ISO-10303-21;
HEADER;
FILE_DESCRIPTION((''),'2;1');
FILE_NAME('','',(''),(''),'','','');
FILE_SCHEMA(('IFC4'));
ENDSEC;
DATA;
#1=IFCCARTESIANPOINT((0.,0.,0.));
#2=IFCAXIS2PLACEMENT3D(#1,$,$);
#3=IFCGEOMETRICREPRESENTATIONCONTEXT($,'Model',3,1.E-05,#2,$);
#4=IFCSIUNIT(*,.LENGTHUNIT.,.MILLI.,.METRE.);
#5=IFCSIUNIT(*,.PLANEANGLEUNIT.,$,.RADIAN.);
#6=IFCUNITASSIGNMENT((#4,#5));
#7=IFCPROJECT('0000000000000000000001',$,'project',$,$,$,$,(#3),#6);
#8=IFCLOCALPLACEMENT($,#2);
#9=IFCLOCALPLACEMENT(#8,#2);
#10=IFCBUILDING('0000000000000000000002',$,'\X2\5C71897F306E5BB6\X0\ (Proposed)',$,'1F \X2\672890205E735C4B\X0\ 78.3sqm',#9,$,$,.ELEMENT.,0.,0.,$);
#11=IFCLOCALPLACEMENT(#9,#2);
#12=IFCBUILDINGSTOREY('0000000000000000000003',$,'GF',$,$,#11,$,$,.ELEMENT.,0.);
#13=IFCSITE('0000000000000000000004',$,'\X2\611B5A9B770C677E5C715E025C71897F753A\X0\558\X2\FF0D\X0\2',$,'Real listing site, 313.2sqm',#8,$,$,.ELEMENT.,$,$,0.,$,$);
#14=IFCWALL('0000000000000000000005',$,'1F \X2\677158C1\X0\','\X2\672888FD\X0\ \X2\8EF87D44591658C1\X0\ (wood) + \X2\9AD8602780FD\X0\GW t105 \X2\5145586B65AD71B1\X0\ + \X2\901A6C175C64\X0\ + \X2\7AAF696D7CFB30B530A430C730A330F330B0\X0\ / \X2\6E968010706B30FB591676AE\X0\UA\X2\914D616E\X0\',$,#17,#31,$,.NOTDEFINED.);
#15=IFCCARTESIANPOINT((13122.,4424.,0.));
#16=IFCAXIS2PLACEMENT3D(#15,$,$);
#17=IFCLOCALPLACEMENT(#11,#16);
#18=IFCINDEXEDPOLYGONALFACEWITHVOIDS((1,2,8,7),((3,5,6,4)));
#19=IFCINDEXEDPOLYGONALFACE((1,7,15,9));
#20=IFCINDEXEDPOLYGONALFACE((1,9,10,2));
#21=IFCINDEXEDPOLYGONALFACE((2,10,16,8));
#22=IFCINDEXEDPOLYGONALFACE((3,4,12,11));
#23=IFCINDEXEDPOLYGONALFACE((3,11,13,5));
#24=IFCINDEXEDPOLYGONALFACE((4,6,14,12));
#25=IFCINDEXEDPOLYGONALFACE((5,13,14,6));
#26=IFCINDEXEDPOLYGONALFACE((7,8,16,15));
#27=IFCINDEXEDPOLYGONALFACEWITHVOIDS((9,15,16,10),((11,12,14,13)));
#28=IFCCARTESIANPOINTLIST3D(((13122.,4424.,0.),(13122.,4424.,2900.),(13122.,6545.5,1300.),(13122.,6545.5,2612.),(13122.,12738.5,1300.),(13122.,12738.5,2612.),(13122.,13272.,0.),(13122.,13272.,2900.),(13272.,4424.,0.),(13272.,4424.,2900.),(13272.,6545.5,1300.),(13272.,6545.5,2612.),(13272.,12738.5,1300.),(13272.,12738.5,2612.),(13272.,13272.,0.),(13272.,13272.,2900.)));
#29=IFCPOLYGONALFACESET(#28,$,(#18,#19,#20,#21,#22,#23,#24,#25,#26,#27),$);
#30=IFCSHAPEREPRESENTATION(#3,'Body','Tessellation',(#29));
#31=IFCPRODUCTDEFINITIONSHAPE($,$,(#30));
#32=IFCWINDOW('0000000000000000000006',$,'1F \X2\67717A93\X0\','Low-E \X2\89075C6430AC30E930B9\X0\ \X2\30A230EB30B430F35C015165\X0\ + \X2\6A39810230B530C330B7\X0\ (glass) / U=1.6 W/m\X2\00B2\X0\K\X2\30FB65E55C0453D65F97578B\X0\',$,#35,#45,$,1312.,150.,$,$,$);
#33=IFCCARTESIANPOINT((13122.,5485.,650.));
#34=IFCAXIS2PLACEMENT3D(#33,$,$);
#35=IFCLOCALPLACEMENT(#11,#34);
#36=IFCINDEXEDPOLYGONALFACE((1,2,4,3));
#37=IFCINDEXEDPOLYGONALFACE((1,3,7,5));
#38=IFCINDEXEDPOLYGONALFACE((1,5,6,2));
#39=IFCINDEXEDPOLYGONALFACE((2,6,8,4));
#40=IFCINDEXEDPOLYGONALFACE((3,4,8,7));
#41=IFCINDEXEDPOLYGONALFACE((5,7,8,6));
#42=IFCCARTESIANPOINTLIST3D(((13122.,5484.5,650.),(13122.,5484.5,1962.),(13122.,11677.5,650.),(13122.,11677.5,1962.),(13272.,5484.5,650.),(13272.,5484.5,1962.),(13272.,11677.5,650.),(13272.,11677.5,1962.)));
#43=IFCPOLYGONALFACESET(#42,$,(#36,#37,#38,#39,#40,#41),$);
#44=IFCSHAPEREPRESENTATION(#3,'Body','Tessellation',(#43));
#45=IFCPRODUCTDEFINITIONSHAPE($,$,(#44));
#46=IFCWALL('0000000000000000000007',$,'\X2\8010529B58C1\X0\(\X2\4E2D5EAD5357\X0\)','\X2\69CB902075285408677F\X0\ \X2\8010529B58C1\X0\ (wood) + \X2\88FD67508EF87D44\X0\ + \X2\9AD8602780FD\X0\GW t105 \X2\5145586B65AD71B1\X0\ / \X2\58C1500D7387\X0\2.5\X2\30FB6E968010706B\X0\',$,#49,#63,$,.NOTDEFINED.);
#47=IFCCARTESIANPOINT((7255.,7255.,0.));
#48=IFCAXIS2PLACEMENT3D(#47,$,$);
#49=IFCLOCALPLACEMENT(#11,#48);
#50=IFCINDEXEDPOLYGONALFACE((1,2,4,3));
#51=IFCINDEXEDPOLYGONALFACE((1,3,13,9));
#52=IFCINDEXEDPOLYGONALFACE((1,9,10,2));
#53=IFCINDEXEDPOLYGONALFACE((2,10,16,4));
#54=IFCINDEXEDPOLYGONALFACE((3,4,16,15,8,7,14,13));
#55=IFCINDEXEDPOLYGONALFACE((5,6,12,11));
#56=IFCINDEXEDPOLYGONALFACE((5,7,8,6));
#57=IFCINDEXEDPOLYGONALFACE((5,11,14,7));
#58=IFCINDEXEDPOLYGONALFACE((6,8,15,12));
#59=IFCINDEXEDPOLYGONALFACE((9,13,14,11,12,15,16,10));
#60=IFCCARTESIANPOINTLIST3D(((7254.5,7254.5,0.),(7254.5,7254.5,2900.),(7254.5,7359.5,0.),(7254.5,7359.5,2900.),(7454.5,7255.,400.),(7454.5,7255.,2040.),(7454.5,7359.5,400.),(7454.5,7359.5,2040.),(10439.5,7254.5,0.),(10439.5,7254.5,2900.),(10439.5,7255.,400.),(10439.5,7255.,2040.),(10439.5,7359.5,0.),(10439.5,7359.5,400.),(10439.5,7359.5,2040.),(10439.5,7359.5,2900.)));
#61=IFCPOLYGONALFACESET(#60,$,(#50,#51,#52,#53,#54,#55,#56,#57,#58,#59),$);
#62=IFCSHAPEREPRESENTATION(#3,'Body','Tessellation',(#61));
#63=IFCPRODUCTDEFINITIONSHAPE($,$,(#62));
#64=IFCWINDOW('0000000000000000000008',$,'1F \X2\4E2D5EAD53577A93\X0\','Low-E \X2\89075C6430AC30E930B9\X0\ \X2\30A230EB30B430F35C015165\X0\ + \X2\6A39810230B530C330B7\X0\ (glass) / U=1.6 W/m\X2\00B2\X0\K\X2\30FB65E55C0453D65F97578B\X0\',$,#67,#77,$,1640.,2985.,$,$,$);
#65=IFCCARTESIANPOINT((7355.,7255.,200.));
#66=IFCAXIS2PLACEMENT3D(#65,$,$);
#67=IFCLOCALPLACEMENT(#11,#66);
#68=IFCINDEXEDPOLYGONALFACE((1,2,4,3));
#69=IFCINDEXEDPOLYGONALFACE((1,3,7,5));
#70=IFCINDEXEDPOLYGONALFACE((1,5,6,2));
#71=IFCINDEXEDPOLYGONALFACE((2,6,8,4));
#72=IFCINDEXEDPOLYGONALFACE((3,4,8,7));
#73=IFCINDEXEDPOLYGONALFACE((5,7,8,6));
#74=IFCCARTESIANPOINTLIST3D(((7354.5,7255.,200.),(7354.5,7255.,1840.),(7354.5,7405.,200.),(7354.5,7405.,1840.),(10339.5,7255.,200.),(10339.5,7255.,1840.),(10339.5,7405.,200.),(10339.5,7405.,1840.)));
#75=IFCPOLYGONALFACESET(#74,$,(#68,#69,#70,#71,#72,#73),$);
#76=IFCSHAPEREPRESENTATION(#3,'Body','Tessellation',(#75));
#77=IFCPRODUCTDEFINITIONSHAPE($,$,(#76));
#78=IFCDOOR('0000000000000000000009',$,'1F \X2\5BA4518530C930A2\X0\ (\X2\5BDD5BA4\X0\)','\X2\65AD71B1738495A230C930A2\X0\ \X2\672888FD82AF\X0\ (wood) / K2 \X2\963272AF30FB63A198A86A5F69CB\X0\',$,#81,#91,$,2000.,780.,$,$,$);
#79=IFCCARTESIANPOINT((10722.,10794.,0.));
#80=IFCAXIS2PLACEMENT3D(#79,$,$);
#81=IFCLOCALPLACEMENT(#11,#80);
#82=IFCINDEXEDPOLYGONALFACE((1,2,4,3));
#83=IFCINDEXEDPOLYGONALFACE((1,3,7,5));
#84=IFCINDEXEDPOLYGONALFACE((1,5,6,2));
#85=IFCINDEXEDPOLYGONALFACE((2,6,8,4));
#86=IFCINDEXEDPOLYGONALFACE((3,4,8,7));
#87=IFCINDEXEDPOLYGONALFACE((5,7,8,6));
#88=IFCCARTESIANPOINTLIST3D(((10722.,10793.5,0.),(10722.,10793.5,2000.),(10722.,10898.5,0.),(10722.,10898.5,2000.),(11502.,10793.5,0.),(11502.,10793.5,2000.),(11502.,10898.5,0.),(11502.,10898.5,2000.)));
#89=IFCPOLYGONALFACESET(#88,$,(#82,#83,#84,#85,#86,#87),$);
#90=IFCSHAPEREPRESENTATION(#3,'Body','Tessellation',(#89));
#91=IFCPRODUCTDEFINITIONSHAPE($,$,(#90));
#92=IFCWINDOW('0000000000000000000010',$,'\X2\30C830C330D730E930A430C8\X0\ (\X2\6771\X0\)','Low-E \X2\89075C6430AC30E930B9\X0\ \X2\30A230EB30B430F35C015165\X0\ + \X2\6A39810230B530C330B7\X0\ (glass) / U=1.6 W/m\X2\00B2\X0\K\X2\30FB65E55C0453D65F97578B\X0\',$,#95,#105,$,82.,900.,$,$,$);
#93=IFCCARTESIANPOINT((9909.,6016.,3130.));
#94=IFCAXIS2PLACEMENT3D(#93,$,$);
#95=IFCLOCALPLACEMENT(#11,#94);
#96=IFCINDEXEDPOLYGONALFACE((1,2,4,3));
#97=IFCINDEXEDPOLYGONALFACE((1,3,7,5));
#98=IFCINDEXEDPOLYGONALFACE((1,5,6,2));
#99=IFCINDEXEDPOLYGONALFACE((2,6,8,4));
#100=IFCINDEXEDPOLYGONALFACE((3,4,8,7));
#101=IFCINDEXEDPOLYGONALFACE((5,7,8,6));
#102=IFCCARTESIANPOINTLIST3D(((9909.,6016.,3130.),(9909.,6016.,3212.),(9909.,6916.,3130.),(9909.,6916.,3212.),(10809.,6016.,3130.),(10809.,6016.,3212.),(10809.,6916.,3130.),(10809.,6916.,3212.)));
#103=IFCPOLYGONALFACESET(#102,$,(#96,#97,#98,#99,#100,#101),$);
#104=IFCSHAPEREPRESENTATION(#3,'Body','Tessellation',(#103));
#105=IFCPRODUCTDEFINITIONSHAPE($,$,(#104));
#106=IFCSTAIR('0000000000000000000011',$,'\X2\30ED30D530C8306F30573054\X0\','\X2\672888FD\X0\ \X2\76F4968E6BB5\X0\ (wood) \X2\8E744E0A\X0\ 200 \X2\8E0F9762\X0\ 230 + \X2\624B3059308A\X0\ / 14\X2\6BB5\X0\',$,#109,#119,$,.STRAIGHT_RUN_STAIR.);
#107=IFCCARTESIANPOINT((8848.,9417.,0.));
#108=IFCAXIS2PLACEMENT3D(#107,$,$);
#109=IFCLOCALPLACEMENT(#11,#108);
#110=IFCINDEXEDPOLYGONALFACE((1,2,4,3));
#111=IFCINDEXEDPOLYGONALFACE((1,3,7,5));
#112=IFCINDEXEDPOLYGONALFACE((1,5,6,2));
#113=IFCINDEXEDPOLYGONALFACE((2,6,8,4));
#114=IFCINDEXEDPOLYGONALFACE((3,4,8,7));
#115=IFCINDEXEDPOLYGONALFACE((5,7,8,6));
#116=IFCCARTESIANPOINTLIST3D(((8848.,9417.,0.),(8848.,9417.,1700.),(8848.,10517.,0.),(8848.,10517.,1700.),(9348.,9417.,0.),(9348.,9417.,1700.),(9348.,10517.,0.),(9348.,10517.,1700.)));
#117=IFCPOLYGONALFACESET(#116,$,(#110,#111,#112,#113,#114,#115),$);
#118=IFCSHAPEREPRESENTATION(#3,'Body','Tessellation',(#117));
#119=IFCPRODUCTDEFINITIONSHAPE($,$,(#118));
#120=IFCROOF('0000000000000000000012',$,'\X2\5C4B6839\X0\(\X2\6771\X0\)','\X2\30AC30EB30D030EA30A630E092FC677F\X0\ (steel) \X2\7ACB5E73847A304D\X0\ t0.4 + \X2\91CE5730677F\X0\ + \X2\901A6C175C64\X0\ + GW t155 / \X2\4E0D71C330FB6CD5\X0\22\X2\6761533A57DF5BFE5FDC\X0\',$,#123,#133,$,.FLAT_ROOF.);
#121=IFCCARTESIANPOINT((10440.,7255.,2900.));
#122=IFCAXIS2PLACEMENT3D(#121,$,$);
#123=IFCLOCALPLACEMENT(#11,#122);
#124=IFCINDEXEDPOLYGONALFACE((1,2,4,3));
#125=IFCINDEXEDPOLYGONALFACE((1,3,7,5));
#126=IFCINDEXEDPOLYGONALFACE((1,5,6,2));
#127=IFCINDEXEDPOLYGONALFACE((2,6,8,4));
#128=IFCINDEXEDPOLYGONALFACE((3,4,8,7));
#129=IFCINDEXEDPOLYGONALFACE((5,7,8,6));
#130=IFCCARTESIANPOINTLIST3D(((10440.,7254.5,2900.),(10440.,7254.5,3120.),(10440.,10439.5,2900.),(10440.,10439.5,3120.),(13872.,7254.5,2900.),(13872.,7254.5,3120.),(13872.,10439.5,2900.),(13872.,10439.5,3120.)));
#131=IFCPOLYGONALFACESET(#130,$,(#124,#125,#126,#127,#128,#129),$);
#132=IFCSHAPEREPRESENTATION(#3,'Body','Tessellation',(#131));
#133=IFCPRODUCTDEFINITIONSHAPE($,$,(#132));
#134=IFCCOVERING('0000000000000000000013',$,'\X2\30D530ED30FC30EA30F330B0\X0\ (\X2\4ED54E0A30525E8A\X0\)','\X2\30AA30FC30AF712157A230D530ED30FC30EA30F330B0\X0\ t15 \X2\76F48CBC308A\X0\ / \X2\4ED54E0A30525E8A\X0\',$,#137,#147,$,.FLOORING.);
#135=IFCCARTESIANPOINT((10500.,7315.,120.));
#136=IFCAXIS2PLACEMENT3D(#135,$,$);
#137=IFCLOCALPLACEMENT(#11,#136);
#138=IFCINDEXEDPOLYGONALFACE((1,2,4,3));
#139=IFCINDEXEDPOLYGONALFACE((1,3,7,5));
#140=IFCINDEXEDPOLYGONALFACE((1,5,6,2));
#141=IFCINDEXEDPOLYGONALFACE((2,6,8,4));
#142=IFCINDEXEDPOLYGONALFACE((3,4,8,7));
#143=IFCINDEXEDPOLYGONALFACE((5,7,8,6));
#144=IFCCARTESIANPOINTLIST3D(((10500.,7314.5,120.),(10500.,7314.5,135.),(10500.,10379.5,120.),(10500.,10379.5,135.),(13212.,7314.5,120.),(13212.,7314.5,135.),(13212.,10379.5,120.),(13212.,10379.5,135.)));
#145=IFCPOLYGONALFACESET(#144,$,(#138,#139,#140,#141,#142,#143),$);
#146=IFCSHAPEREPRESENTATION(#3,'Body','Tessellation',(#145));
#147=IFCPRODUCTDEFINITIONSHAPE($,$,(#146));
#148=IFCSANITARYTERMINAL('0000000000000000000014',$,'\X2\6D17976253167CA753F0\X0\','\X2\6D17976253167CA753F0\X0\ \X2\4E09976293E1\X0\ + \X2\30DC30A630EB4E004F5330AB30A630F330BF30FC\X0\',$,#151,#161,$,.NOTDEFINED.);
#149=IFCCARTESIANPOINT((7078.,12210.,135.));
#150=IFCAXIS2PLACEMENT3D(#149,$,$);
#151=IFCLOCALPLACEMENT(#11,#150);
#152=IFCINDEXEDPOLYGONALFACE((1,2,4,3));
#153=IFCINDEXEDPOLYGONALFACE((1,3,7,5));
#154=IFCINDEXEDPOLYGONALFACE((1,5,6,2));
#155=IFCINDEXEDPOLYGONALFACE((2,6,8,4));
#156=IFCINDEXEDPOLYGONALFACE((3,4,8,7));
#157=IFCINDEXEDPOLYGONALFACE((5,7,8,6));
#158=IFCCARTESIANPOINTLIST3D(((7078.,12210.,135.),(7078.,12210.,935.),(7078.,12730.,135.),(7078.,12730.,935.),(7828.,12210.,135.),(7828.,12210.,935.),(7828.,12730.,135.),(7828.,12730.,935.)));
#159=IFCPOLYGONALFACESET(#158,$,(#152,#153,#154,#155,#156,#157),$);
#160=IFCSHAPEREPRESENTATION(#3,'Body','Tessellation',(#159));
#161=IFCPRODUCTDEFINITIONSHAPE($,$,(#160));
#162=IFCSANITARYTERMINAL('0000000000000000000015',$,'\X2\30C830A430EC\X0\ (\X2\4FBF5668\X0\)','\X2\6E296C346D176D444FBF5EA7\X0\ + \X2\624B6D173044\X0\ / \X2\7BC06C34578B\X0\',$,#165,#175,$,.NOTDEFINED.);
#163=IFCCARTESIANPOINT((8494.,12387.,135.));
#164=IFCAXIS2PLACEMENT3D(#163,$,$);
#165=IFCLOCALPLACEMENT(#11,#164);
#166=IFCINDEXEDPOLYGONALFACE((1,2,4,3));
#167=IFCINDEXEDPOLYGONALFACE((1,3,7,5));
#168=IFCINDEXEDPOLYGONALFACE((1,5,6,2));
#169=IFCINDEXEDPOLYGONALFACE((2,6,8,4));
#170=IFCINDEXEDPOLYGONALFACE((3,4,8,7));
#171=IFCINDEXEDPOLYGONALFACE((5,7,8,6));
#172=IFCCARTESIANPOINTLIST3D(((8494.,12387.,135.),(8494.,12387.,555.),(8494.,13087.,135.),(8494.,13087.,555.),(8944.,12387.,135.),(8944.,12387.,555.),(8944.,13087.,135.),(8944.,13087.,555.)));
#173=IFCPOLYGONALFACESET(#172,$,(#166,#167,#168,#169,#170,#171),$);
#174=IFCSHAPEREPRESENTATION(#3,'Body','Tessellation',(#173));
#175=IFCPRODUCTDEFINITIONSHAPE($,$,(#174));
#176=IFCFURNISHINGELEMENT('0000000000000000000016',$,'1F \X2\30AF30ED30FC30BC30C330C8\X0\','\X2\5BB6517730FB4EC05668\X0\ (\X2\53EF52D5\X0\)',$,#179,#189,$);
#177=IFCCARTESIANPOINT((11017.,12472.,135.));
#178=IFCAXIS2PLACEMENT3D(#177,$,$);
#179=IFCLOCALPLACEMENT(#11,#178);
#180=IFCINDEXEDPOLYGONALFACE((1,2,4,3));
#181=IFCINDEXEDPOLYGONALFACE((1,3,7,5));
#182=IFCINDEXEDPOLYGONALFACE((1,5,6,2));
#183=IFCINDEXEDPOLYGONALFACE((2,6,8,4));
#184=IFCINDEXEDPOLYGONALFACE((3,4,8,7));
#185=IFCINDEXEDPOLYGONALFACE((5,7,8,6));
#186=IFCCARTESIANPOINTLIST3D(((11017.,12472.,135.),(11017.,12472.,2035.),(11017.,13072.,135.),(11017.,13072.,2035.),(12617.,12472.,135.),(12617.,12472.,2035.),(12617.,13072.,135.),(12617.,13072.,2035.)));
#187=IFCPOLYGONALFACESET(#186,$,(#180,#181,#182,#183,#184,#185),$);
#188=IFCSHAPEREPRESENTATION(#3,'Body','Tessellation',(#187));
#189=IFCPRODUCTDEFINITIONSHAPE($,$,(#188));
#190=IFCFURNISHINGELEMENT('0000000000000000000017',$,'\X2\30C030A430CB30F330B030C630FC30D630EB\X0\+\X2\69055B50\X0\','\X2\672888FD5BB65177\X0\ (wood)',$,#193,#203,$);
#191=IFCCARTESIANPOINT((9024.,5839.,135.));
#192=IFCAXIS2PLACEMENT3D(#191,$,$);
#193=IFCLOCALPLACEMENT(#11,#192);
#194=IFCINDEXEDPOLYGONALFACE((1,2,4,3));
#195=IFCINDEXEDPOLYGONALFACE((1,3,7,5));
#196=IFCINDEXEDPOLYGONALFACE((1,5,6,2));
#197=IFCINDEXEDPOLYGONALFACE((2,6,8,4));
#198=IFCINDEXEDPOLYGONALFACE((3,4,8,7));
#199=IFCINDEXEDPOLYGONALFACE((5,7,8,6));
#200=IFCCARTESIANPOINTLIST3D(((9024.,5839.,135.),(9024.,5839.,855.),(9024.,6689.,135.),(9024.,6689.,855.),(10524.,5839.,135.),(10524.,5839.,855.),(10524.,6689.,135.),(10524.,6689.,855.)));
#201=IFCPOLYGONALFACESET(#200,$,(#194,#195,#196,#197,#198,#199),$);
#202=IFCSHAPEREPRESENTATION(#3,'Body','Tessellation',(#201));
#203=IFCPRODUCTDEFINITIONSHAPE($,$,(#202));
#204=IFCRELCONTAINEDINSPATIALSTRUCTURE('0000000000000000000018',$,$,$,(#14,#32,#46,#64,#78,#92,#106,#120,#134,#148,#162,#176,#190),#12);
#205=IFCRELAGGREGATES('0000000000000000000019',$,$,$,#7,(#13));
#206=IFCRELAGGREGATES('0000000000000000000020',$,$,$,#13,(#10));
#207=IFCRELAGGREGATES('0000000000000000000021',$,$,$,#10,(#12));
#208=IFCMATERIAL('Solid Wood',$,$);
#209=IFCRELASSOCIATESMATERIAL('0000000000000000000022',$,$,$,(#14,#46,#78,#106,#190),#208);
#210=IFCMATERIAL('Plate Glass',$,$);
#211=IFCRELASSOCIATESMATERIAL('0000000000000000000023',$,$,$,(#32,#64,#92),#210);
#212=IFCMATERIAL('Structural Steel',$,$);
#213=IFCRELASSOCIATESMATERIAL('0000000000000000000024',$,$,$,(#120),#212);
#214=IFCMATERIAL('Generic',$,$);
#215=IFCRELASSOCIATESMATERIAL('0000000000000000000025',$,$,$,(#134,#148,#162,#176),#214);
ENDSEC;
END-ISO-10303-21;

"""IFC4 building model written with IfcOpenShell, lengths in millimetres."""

from ifc_helpers import new_model, si_unit, frame, frame_2d, origin, place, context, project, spatial, rectangle, extrude, material, element, fill, save


model = new_model("IFC4")

# Units and contexts
model_context = context("Model", 3, precision=1e-05, world=origin())
ifc_project = project(units=[si_unit("LENGTHUNIT", "METRE", prefix="MILLI"), si_unit("PLANEANGLEUNIT", "RADIAN")], contexts=[model_context])

# Site, building, storey
site_placement = place(None, origin())
site = spatial("IfcSite", under=ifc_project, at=site_placement, Name="愛媛県松山市山西町558－2", ObjectType="Real listing site, 313.2sqm", CompositionType="ELEMENT", RefElevation=0.0)
building_placement = place(site_placement, origin())
building = spatial("IfcBuilding", under=site, at=building_placement, Name="山西の家 (Proposed)", ObjectType="1F 木造平屋 78.3sqm", CompositionType="ELEMENT", ElevationOfRefHeight=0.0, ElevationOfTerrain=0.0)
storey_placement = place(building_placement, origin())
storey = spatial("IfcBuildingStorey", under=building, at=storey_placement, Name="GF", CompositionType="ELEMENT", Elevation=0.0)

# Shared definitions
ifc_material_1 = material(Name="Solid Wood")

# Walls, openings, windows
wall_1_placement = place(storey_placement, frame((13122.0, 4424.0, 0.0)))
wall_1 = element("IfcWall", 1, at=wall_1_placement, inside=storey, material=ifc_material_1, Name="1F 東壁", Description="木製 軸組外壁 (wood) + 高性能GW t105 充填断熱 + 通気層 + 窯業系サイディング / 準耐火・外皮UA配慮", PredefinedType="NOTDEFINED", context=model_context, shape_type="SweptSolid", body=[
    extrude(rectangle(XDim=150.0, YDim=8848.0, at=frame_2d((75.0, 4424.0))), frame((13122.0, 4424.0, 0.0)), (0.0, 0.0, 1.0), 2900.0),
])
opening_1_placement = place(storey_placement, frame((13122.0, 5485.0, 650.0)))
opening_1 = element("IfcOpeningElement", 2, at=opening_1_placement, cuts=wall_1, PredefinedType="NOTDEFINED", context=model_context, shape_type="SweptSolid", body=[
    extrude(rectangle(XDim=150.0, YDim=6193.0, at=frame_2d((75.0, 3096.0))), frame((13122.0, 5485.0, 650.0)), (0.0, 0.0, 1.0), 1312.0),
])
ifc_material_2 = material(Name="Plate Glass")
window_1_placement = place(storey_placement, frame((13122.0, 5485.0, 650.0)))
window_1 = element("IfcWindow", 3, at=window_1_placement, inside=storey, material=ifc_material_2, Name="1F 東窓", Description="Low-E 複層ガラス アルゴン封入 + 樹脂サッシ (glass) / U=1.6 W/m²K・日射取得型", OverallHeight=1312.0, OverallWidth=150.0, context=model_context, shape_type="SweptSolid", body=[
    extrude(rectangle(XDim=150.0, YDim=6193.0, at=frame_2d((75.0, 3096.0))), frame((13122.0, 5485.0, 650.0)), (0.0, 0.0, 1.0), 1312.0),
])
fill(opening_1, window_1)
wall_2_placement = place(storey_placement, frame((7255.0, 7255.0, 0.0)))
wall_2 = element("IfcWall", 4, at=wall_2_placement, inside=storey, material=ifc_material_1, Name="耐力壁(中庭南)", Description="構造用合板 耐力壁 (wood) + 製材軸組 + 高性能GW t105 充填断熱 / 壁倍率2.5・準耐火", PredefinedType="NOTDEFINED", context=model_context, shape_type="SweptSolid", body=[
    extrude(rectangle(XDim=3185.0, YDim=105.0, at=frame_2d((1592.0, 52.0))), frame((7255.0, 7255.0, 0.0)), (0.0, 0.0, 1.0), 2900.0),
])
opening_2_placement = place(storey_placement, frame((7355.0, 7255.0, 200.0)))
opening_2 = element("IfcOpeningElement", 5, at=opening_2_placement, cuts=wall_2, PredefinedType="NOTDEFINED", context=model_context, shape_type="SweptSolid", body=[
    extrude(rectangle(XDim=2985.0, YDim=150.0, at=frame_2d((1492.0, 75.0))), frame((7355.0, 7255.0, 200.0)), (0.0, 0.0, 1.0), 1640.0),
])
window_2_placement = place(storey_placement, frame((7355.0, 7255.0, 200.0)))
window_2 = element("IfcWindow", 6, at=window_2_placement, inside=storey, material=ifc_material_2, Name="1F 中庭南窓", Description="Low-E 複層ガラス アルゴン封入 + 樹脂サッシ (glass) / U=1.6 W/m²K・日射取得型", OverallHeight=1640.0, OverallWidth=2985.0, context=model_context, shape_type="SweptSolid", body=[
    extrude(rectangle(XDim=2985.0, YDim=150.0, at=frame_2d((1492.0, 75.0))), frame((7355.0, 7255.0, 200.0)), (0.0, 0.0, 1.0), 1640.0),
])
fill(opening_2, window_2)

# Door
door_placement = place(storey_placement, frame((10722.0, 10794.0, 0.0)))
element("IfcDoor", 7, at=door_placement, inside=storey, material=ifc_material_1, Name="1F 室内ドア (寝室)", Description="断熱玄関ドア 木製芯 (wood) / K2 防犯・採風機構", OverallHeight=2000.0, OverallWidth=780.0, context=model_context, shape_type="SweptSolid", body=[
    extrude(rectangle(XDim=780.0, YDim=105.0, at=frame_2d((390.0, 52.0))), frame((10722.0, 10794.0, 0.0)), (0.0, 0.0, 1.0), 2000.0),
])

# Window
window_3_placement = place(storey_placement, frame((9909.0, 6016.0, 3130.0)))
element("IfcWindow", 8, at=window_3_placement, inside=storey, material=ifc_material_2, Name="トップライト (東)", Description="Low-E 複層ガラス アルゴン封入 + 樹脂サッシ (glass) / U=1.6 W/m²K・日射取得型", OverallHeight=82.0, OverallWidth=900.0, context=model_context, shape_type="SweptSolid", body=[
    extrude(rectangle(XDim=900.0, YDim=900.0, at=frame_2d((450.0, 450.0))), frame((9909.0, 6016.0, 3130.0)), (0.0, 0.0, 1.0), 82.0),
])

# Stair
stair_placement = place(storey_placement, frame((8848.0, 9417.0, 0.0)))
element("IfcStair", 9, at=stair_placement, inside=storey, material=ifc_material_1, Name="ロフトはしご", Description="木製 直階段 (wood) 蹴上 200 踏面 230 + 手すり / 14段", PredefinedType="STRAIGHT_RUN_STAIR", context=model_context, shape_type="SweptSolid", body=[
    extrude(rectangle(XDim=500.0, YDim=1100.0, at=frame_2d((250.0, 550.0))), frame((8848.0, 9417.0, 0.0)), (0.0, 0.0, 1.0), 1700.0),
])

# Roof
ifc_material_3 = material(Name="Structural Steel")
roof_placement = place(storey_placement, frame((10440.0, 7255.0, 2900.0)))
element("IfcRoof", 10, at=roof_placement, inside=storey, material=ifc_material_3, Name="屋根(東)", Description="ガルバリウム鋼板 (steel) 立平葺き t0.4 + 野地板 + 通気層 + GW t155 / 不燃・法22条区域対応", PredefinedType="FLAT_ROOF", context=model_context, shape_type="SweptSolid", body=[
    extrude(rectangle(XDim=3432.0, YDim=3185.0, at=frame_2d((1716.0, 1592.0))), frame((10440.0, 7255.0, 2900.0)), (0.0, 0.0, 1.0), 220.0),
])

# Covering
ifc_material_4 = material(Name="Generic")
covering_placement = place(storey_placement, frame((10500.0, 7315.0, 120.0)))
element("IfcCovering", 11, at=covering_placement, inside=storey, material=ifc_material_4, Name="フローリング (仕上げ床)", Description="オーク無垢フローリング t15 直貼り / 仕上げ床", PredefinedType="FLOORING", context=model_context, shape_type="SweptSolid", body=[
    extrude(rectangle(XDim=2712.0, YDim=3065.0, at=frame_2d((1356.0, 1532.0))), frame((10500.0, 7315.0, 120.0)), (0.0, 0.0, 1.0), 15.0),
])

# Sanitary terminals
sanitary_terminal_1_placement = place(storey_placement, frame((7078.0, 12210.0, 135.0)))
element("IfcSanitaryTerminal", 12, at=sanitary_terminal_1_placement, inside=storey, material=ifc_material_4, Name="洗面化粧台", Description="洗面化粧台 三面鏡 + ボウル一体カウンター", PredefinedType="NOTDEFINED", context=model_context, shape_type="SweptSolid", body=[
    extrude(rectangle(XDim=750.0, YDim=520.0, at=frame_2d((375.0, 260.0))), frame((7078.0, 12210.0, 135.0)), (0.0, 0.0, 1.0), 800.0),
])
sanitary_terminal_2_placement = place(storey_placement, frame((8494.0, 12387.0, 135.0)))
element("IfcSanitaryTerminal", 13, at=sanitary_terminal_2_placement, inside=storey, material=ifc_material_4, Name="トイレ (便器)", Description="温水洗浄便座 + 手洗い / 節水型", PredefinedType="NOTDEFINED", context=model_context, shape_type="SweptSolid", body=[
    extrude(rectangle(XDim=450.0, YDim=700.0, at=frame_2d((225.0, 350.0))), frame((8494.0, 12387.0, 135.0)), (0.0, 0.0, 1.0), 420.0),
])

# Furnishing elements
furnishing_1_placement = place(storey_placement, frame((11017.0, 12472.0, 135.0)))
element("IfcFurnishingElement", 14, at=furnishing_1_placement, inside=storey, material=ifc_material_4, Name="1F クローゼット", Description="家具・什器 (可動)", context=model_context, shape_type="SweptSolid", body=[
    extrude(rectangle(XDim=1600.0, YDim=600.0, at=frame_2d((800.0, 300.0))), frame((11017.0, 12472.0, 135.0)), (0.0, 0.0, 1.0), 1900.0),
])
furnishing_2_placement = place(storey_placement, frame((9024.0, 5839.0, 135.0)))
element("IfcFurnishingElement", 15, at=furnishing_2_placement, inside=storey, material=ifc_material_1, Name="ダイニングテーブル+椅子", Description="木製家具 (wood)", context=model_context, shape_type="SweptSolid", body=[
    extrude(rectangle(XDim=1500.0, YDim=850.0, at=frame_2d((750.0, 425.0))), frame((9024.0, 5839.0, 135.0)), (0.0, 0.0, 1.0), 720.0),
])

save(model, "model.ifc")
